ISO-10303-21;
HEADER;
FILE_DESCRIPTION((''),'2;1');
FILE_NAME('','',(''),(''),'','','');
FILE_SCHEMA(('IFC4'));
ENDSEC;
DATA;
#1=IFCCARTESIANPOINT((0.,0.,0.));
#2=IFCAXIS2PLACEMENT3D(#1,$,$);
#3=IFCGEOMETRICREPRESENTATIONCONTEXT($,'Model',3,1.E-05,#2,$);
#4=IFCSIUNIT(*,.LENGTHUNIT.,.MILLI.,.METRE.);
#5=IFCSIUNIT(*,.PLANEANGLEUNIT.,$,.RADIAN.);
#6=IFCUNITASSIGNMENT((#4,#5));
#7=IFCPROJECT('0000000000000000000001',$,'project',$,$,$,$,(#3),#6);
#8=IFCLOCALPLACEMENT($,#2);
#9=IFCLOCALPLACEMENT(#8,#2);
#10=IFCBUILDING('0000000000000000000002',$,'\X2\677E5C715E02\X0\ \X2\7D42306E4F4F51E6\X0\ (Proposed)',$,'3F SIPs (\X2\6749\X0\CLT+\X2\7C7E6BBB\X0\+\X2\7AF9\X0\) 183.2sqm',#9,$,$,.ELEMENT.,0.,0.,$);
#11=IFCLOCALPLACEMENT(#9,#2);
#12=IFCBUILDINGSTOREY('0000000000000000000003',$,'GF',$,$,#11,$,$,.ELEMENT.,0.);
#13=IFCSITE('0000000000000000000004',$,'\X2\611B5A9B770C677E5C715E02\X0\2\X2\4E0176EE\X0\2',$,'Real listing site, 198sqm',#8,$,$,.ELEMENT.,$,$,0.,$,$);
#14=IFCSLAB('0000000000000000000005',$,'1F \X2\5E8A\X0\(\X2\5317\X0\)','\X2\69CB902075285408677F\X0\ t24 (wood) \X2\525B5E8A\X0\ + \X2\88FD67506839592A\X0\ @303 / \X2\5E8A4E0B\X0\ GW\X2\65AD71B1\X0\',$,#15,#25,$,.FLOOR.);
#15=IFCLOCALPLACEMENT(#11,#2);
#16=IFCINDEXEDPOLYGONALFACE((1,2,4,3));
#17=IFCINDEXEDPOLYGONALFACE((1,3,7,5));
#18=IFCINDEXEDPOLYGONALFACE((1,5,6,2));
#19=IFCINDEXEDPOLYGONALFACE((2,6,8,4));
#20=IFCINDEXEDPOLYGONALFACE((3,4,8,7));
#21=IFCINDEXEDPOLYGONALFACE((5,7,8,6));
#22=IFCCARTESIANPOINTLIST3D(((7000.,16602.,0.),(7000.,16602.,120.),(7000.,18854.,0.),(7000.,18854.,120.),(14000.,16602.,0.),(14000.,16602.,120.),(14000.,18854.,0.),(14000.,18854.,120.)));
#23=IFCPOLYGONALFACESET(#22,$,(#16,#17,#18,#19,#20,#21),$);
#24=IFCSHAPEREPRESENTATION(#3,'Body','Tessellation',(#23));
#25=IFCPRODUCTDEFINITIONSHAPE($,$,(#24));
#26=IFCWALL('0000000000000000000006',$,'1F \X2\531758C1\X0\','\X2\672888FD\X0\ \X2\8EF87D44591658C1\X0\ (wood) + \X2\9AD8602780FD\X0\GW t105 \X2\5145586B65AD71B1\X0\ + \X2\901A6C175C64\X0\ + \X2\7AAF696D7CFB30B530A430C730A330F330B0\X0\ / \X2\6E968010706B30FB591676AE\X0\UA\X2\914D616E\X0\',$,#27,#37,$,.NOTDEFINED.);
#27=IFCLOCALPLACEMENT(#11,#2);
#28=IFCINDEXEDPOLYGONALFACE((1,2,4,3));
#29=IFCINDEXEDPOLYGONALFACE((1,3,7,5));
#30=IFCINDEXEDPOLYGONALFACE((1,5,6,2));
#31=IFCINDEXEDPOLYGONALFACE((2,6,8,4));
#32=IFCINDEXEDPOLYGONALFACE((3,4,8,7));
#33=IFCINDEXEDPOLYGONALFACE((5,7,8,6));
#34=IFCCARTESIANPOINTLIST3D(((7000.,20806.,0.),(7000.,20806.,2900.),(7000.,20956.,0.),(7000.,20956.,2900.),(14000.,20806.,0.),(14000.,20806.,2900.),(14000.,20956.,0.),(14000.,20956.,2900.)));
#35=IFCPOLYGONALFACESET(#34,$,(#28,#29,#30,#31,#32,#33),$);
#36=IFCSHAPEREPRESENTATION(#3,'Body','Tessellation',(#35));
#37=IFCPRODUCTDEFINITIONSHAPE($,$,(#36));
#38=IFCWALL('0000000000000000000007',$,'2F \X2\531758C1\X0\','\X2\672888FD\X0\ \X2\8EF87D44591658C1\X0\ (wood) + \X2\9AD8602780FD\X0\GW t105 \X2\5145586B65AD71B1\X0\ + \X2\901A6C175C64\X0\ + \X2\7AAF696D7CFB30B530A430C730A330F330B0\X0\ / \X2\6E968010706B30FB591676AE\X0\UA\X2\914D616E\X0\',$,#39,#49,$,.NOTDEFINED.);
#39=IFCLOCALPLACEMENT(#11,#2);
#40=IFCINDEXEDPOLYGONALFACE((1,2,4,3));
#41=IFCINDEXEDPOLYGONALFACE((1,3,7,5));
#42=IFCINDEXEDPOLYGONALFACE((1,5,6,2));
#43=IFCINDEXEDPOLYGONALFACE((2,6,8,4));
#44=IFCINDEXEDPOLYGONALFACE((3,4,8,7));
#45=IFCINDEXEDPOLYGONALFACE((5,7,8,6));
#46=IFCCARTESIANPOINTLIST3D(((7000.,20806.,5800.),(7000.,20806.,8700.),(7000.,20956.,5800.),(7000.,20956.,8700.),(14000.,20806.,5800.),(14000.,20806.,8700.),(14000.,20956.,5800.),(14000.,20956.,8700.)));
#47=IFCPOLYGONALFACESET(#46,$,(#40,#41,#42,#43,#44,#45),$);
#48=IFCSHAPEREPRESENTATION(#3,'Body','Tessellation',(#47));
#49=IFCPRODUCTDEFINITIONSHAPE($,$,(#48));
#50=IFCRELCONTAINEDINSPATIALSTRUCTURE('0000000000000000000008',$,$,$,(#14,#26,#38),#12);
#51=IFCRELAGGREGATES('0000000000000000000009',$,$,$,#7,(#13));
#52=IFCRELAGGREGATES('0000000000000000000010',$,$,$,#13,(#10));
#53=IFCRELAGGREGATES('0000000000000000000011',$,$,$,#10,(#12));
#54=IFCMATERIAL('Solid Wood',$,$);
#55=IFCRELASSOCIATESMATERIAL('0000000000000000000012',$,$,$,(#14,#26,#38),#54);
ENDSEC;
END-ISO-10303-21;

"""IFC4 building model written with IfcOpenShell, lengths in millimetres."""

from ifc_helpers import new_model, si_unit, frame, frame_2d, origin, place, context, project, spatial, rectangle, extrude, material, element, save


model = new_model("IFC4")

# Units and contexts
model_context = context("Model", 3, precision=1e-05, world=origin())
ifc_project = project(units=[si_unit("LENGTHUNIT", "METRE", prefix="MILLI"), si_unit("PLANEANGLEUNIT", "RADIAN")], contexts=[model_context])

# Site, building, storey
site_placement = place(None, origin())
site = spatial("IfcSite", under=ifc_project, at=site_placement, Name="愛媛県松山市2丁目2", ObjectType="Real listing site, 198sqm", CompositionType="ELEMENT", RefElevation=0.0)
building_placement = place(site_placement, origin())
building = spatial("IfcBuilding", under=site, at=building_placement, Name="松山市 終の住処 (Proposed)", ObjectType="3F SIPs (杉CLT+籾殻+竹) 183.2sqm", CompositionType="ELEMENT", ElevationOfRefHeight=0.0, ElevationOfTerrain=0.0)
storey_placement = place(building_placement, origin())
storey = spatial("IfcBuildingStorey", under=building, at=storey_placement, Name="GF", CompositionType="ELEMENT", Elevation=0.0)

# Slab
ifc_material_1 = material(Name="Solid Wood")
slab_1_placement = place(storey_placement, frame((3500.0, 8301.0, 0.0)))
element("IfcSlab", 1, at=slab_1_placement, inside=storey, material=ifc_material_1, Name="1F 床(北)", Description="構造用合板 t24 (wood) 剛床 + 製材根太 @303 / 床下 GW断熱", PredefinedType="FLOOR", context=model_context, shape_type="SweptSolid", body=[
    extrude(rectangle(XDim=7000.0, YDim=2252.0, at=frame_2d((3500.0, 1126.0))), frame((3500.0, 8301.0, 0.0)), (0.0, 0.0, 1.0), 120.0),
])

# Wall
wall_1_placement = place(storey_placement, frame((3500.0, 10403.0, 0.0)))
element("IfcWall", 2, at=wall_1_placement, inside=storey, material=ifc_material_1, Name="1F 北壁", Description="木製 軸組外壁 (wood) + 高性能GW t105 充填断熱 + 通気層 + 窯業系サイディング / 準耐火・外皮UA配慮", PredefinedType="NOTDEFINED", context=model_context, shape_type="SweptSolid", body=[
    extrude(rectangle(XDim=7000.0, YDim=150.0, at=frame_2d((3500.0, 75.0))), frame((3500.0, 10403.0, 0.0)), (0.0, 0.0, 1.0), 2900.0),
])

# Wall
wall_2_placement = place(storey_placement, frame((3500.0, 10403.0, 2900.0)))
element("IfcWall", 3, at=wall_2_placement, inside=storey, material=ifc_material_1, Name="2F 北壁", Description="木製 軸組外壁 (wood) + 高性能GW t105 充填断熱 + 通気層 + 窯業系サイディング / 準耐火・外皮UA配慮", PredefinedType="NOTDEFINED", context=model_context, shape_type="SweptSolid", body=[
    extrude(rectangle(XDim=7000.0, YDim=150.0, at=frame_2d((3500.0, 75.0))), frame((3500.0, 10403.0, 2900.0)), (0.0, 0.0, 1.0), 2900.0),
])

save(model, "model.ifc")
